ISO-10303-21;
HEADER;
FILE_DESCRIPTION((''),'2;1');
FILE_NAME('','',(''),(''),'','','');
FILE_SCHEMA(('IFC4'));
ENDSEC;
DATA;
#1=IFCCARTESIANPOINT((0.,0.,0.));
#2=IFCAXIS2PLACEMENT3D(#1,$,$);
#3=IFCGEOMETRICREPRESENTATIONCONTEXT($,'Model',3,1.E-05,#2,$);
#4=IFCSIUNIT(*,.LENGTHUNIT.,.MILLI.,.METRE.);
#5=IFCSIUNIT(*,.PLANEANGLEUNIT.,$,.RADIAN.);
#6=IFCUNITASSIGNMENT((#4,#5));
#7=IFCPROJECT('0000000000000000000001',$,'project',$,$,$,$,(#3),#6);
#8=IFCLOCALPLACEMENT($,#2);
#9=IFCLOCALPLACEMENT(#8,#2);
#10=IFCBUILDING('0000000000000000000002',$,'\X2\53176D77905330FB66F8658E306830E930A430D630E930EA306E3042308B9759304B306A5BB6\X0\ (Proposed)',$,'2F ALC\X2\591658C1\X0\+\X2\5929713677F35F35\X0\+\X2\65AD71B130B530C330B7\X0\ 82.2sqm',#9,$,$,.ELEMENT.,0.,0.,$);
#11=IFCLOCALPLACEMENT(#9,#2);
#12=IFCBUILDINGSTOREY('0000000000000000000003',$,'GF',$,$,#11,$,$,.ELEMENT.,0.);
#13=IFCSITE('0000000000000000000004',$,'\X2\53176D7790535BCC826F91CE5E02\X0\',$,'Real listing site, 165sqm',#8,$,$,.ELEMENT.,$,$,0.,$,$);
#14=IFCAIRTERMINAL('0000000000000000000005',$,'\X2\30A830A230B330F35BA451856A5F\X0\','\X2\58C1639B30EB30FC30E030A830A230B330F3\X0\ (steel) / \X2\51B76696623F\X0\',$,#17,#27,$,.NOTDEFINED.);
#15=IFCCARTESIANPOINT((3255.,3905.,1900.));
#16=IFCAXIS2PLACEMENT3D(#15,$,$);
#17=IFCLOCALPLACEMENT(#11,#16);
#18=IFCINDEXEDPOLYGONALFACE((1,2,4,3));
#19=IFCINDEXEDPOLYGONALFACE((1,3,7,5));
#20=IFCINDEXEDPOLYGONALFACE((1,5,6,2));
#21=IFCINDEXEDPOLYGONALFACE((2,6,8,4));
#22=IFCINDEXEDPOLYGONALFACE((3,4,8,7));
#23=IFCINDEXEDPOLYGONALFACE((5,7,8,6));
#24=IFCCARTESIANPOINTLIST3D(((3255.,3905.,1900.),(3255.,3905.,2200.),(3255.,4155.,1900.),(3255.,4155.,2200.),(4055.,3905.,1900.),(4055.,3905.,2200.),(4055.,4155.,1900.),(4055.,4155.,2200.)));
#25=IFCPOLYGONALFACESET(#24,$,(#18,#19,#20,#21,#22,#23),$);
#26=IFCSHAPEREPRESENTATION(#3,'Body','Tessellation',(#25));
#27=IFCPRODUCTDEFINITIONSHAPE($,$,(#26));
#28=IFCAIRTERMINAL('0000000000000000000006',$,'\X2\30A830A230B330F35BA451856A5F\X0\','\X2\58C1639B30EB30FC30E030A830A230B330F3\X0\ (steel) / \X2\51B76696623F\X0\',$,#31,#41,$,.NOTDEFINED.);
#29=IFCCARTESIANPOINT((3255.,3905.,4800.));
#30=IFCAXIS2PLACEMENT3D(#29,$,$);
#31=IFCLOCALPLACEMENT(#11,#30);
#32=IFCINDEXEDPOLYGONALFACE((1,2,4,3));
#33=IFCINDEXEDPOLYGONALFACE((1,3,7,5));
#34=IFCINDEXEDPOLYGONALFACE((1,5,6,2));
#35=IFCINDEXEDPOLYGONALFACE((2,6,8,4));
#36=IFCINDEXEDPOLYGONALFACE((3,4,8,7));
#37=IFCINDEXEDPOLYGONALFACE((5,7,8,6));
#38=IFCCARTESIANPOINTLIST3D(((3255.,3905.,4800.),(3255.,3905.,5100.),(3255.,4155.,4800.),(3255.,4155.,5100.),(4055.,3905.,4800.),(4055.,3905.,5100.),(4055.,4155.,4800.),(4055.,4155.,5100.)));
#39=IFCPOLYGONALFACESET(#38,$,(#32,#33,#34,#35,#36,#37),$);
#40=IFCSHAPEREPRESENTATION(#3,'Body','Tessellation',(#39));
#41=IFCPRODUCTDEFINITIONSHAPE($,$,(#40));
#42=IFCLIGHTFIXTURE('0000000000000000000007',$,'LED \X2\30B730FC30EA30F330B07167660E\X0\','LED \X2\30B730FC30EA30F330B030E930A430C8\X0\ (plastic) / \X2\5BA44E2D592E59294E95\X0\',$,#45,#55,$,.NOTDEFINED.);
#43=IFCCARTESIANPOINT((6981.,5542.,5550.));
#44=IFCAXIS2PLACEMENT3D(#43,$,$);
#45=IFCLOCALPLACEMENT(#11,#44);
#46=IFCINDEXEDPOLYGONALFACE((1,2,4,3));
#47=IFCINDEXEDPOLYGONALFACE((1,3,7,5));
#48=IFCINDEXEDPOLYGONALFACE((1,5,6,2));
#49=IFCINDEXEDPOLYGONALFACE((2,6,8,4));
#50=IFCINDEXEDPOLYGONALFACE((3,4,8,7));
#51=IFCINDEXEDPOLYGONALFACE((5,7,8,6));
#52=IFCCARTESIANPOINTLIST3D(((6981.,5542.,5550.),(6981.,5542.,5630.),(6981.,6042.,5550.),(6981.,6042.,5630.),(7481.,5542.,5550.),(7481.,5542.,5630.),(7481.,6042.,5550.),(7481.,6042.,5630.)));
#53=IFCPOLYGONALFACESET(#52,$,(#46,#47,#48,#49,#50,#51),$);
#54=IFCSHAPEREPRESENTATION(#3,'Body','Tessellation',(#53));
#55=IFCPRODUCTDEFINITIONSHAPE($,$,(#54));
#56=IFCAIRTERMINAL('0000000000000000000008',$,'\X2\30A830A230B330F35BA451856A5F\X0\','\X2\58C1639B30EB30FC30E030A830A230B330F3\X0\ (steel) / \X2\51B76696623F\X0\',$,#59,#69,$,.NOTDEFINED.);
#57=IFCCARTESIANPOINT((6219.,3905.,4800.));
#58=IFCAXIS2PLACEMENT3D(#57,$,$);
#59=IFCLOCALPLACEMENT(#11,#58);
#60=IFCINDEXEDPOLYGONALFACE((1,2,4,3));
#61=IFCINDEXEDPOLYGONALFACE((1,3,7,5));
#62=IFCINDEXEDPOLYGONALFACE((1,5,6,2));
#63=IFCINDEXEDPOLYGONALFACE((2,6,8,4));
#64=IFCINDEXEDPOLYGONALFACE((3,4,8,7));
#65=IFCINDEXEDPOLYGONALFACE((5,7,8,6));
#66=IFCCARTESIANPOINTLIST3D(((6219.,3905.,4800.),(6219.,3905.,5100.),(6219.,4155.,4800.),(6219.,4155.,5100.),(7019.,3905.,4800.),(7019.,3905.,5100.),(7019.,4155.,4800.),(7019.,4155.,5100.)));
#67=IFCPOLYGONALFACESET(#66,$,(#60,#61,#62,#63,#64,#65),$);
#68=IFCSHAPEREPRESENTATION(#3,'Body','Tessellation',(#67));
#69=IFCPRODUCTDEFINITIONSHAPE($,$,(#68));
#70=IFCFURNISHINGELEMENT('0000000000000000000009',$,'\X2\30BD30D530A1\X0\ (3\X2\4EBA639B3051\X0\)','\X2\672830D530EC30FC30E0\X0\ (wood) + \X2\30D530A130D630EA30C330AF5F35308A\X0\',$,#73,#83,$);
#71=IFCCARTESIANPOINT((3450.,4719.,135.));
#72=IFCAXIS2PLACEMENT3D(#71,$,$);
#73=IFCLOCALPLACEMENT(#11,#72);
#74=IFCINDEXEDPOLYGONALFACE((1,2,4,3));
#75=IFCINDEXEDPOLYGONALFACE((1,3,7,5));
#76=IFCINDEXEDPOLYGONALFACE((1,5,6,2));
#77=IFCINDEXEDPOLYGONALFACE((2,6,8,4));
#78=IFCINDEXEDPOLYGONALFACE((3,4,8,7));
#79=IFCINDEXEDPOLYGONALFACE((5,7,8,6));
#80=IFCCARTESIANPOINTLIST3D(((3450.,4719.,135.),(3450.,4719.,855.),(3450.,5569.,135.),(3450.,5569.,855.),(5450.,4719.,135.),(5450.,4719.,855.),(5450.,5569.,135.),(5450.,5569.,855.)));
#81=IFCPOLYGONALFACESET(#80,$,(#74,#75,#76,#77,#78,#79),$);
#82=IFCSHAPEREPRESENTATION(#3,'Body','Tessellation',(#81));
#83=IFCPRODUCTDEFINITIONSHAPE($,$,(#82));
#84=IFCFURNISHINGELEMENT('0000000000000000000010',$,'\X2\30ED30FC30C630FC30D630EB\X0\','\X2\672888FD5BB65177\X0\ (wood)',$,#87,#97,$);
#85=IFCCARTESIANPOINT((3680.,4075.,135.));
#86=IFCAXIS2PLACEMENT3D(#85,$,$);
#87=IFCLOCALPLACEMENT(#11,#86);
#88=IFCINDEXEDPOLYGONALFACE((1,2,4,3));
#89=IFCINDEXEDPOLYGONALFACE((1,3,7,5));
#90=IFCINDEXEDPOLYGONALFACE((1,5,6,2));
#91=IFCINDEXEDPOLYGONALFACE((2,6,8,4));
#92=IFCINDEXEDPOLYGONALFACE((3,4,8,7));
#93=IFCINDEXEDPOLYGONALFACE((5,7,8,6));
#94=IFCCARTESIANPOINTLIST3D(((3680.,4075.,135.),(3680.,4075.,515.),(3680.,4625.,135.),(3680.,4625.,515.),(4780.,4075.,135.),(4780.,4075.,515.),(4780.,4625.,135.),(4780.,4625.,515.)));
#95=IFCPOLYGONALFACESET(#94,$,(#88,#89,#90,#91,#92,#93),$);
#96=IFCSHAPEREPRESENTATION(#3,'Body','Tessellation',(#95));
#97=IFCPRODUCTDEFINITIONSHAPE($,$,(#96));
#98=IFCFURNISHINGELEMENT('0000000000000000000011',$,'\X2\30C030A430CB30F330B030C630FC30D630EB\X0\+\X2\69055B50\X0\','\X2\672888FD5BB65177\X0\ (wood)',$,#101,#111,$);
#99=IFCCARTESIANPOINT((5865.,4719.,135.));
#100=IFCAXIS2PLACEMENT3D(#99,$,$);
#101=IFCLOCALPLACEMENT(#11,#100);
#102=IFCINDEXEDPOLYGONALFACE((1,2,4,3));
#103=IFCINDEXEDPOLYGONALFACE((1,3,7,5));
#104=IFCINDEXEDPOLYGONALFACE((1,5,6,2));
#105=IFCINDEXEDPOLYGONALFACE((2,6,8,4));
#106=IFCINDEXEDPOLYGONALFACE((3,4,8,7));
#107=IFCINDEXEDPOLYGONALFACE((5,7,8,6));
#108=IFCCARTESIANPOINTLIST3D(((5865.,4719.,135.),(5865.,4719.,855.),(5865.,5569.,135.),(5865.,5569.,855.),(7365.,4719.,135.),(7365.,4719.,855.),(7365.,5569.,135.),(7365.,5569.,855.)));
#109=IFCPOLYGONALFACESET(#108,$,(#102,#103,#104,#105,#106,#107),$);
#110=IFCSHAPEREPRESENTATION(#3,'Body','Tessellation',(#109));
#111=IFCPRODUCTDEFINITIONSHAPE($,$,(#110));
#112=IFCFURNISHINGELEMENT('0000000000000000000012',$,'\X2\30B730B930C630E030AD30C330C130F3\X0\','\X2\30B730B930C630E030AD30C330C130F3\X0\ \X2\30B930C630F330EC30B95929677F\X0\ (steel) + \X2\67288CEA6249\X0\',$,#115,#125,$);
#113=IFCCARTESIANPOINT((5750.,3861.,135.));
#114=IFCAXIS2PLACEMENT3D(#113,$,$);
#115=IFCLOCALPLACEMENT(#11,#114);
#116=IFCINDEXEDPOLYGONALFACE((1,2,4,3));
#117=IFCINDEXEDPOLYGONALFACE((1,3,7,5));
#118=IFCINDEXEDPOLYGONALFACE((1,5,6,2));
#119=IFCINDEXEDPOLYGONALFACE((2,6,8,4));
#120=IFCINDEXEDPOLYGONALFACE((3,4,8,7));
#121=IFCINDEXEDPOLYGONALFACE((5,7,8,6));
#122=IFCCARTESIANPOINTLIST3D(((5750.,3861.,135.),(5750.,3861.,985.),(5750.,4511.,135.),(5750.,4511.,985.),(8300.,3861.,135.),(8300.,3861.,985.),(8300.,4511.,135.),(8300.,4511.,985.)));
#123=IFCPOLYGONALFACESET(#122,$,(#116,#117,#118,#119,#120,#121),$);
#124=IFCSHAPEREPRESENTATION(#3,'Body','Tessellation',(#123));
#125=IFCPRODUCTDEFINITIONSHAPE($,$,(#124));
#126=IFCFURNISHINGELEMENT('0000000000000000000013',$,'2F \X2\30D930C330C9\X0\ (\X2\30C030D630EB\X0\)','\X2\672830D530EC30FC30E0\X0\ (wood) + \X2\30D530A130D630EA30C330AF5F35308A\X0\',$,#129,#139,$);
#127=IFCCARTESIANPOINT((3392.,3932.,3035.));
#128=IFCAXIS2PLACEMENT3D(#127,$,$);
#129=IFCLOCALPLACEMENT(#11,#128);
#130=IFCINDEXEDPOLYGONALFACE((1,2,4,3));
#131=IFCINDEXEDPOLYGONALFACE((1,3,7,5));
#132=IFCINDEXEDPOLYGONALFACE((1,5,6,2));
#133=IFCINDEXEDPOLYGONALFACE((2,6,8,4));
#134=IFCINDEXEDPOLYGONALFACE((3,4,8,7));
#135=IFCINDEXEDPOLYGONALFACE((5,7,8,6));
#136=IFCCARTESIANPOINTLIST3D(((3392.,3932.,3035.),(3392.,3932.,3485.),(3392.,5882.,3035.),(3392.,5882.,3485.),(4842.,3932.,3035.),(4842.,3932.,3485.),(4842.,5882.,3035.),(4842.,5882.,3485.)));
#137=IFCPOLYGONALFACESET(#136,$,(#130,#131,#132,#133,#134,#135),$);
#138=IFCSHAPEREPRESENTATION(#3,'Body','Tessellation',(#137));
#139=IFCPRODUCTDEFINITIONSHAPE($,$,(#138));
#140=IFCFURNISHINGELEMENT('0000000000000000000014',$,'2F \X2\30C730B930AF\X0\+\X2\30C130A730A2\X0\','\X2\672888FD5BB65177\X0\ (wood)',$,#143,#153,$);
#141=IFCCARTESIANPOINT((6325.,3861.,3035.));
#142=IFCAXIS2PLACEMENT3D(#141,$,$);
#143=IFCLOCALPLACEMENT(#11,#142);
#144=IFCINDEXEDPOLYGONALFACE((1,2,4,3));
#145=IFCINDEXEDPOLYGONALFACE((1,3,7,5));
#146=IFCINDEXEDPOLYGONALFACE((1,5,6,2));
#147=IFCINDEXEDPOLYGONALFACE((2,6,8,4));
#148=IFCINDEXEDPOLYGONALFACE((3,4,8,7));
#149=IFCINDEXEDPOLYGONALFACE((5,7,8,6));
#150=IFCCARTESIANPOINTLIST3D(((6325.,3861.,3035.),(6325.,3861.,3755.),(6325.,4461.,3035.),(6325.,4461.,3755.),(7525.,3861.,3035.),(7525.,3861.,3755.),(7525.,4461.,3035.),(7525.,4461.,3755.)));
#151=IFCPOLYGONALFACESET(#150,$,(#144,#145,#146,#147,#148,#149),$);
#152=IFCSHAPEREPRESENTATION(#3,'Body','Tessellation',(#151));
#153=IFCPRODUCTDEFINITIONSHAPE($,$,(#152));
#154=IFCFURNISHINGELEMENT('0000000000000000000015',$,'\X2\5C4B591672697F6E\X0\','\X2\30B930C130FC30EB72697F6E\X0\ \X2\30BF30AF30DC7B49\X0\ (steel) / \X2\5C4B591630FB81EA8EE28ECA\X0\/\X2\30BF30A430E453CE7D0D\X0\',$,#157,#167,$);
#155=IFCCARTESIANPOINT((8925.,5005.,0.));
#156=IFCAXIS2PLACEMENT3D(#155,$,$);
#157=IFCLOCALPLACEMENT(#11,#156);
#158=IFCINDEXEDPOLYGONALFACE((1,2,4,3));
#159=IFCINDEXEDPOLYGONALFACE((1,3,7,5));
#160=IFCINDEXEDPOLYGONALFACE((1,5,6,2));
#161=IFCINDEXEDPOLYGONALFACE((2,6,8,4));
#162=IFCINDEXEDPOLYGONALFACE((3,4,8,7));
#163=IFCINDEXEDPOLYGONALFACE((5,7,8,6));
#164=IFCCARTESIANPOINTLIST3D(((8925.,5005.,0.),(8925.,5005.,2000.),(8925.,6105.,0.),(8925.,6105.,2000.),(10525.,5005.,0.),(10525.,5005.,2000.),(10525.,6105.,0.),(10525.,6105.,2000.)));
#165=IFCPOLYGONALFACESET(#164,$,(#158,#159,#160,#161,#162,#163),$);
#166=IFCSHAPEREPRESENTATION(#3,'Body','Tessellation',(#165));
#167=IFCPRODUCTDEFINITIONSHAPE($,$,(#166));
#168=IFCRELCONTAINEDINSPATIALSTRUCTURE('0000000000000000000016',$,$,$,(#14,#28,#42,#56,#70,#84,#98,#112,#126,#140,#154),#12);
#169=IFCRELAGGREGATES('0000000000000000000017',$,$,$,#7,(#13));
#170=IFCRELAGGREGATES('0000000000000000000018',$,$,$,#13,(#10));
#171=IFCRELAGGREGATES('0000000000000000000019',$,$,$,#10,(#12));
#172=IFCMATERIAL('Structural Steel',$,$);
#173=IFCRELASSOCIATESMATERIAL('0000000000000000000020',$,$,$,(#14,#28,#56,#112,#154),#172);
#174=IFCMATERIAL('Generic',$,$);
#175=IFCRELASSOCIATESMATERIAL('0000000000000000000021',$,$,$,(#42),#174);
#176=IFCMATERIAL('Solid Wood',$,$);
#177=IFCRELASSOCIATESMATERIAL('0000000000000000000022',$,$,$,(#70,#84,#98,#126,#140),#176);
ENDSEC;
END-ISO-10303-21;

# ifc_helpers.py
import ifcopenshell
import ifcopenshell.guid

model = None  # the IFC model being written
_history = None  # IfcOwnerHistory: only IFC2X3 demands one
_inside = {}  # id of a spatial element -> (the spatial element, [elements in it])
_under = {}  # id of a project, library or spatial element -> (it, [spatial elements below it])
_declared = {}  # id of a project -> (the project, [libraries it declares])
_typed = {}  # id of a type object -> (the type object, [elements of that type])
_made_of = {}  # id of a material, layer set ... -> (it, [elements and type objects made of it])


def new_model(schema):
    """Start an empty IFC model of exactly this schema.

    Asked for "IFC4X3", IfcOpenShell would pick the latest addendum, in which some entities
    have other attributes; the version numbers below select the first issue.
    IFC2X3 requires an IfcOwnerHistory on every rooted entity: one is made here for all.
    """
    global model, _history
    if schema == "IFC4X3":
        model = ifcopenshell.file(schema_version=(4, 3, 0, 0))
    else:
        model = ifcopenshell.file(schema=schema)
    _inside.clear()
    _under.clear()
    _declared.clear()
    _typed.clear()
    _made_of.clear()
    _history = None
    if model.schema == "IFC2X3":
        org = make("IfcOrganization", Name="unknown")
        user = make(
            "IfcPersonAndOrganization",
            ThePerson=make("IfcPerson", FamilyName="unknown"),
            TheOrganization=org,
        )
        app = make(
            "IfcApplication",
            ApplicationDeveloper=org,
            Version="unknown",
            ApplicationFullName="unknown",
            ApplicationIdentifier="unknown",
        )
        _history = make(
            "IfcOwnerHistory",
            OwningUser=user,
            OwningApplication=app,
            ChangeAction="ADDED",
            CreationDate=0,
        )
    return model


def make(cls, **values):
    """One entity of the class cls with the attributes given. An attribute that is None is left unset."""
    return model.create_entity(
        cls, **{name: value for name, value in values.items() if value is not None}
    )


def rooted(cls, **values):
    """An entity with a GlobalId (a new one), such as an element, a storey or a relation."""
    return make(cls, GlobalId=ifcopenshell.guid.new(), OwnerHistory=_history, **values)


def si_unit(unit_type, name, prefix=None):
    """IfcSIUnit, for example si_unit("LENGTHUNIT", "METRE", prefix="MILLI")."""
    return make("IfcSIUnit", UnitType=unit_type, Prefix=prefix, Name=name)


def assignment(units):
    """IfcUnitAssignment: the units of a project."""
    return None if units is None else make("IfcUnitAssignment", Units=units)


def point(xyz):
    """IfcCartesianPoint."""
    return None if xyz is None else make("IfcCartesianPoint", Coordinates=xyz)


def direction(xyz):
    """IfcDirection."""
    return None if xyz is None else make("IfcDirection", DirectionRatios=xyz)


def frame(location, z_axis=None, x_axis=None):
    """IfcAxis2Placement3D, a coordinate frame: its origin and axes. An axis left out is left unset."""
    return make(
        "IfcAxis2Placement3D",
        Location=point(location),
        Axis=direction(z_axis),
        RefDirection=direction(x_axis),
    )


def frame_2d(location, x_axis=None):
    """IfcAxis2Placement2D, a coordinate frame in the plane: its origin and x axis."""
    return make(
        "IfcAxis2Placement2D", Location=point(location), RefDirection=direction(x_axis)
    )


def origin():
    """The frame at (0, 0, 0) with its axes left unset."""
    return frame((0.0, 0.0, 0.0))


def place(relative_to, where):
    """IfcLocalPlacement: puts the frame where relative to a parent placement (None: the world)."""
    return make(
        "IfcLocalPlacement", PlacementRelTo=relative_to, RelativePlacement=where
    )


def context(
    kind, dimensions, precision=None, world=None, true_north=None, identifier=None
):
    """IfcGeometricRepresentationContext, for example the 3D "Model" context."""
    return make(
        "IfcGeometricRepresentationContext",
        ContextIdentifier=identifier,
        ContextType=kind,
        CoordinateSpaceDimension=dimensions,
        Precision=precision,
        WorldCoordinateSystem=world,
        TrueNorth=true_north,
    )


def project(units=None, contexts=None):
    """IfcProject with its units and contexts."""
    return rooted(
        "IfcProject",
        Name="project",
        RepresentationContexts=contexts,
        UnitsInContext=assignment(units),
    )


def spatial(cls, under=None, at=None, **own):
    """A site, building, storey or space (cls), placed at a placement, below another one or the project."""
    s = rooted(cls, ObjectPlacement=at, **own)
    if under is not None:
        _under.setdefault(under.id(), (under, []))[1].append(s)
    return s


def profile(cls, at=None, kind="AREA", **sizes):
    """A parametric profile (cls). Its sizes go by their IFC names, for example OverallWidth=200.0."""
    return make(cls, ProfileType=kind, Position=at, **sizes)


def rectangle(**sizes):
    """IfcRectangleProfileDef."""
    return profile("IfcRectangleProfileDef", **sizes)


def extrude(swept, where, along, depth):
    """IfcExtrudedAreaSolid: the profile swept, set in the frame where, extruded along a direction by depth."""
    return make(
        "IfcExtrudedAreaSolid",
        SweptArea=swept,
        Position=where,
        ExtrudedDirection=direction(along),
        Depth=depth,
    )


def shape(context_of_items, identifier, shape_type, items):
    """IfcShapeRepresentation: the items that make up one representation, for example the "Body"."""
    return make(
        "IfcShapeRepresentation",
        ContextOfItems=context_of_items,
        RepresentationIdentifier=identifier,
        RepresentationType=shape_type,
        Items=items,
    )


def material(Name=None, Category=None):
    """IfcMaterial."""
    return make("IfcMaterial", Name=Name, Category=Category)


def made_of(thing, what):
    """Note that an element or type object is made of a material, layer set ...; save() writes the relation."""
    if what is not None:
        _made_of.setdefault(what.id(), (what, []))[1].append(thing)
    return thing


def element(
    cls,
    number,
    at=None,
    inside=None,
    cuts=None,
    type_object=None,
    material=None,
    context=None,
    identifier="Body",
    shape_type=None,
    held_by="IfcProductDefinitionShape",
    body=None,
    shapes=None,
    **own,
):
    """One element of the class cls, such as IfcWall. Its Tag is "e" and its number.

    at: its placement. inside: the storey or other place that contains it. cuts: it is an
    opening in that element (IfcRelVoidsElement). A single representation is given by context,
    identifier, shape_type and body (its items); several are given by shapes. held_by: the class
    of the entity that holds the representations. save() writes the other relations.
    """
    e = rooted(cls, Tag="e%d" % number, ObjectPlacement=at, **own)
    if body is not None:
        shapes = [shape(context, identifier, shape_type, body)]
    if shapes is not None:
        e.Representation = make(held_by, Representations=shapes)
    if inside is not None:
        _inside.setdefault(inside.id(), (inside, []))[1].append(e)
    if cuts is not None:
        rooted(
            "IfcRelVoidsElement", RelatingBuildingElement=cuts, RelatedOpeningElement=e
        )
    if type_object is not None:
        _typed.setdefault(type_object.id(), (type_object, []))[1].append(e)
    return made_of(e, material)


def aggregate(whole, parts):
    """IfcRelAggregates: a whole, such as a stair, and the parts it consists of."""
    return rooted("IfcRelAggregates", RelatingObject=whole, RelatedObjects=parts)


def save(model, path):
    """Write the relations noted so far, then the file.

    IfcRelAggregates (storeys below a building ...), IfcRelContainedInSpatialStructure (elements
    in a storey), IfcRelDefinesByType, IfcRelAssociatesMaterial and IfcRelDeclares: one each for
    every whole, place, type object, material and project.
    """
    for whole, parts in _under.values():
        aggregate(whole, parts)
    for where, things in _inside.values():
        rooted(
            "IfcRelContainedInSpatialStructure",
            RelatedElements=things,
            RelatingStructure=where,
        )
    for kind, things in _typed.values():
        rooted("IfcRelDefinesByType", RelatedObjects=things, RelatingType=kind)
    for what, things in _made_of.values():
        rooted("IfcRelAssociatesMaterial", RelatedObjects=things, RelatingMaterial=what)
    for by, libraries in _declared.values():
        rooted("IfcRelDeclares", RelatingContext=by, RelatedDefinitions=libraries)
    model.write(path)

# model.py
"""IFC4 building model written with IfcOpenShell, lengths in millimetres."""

from ifc_helpers import new_model, si_unit, frame, frame_2d, origin, place, context, project, spatial, rectangle, extrude, material, element, save


model = new_model("IFC4")

# Units and contexts
model_context = context("Model", 3, precision=1e-05, world=origin())
ifc_project = project(units=[si_unit("LENGTHUNIT", "METRE", prefix="MILLI"), si_unit("PLANEANGLEUNIT", "RADIAN")], contexts=[model_context])

# Site, building, storey
site_placement = place(None, origin())
site = spatial("IfcSite", under=ifc_project, at=site_placement, Name="北海道富良野市", ObjectType="Real listing site, 165sqm", CompositionType="ELEMENT", RefElevation=0.0)
building_placement = place(site_placement, origin())
building = spatial("IfcBuilding", under=site, at=building_placement, Name="北海道・書斎とライブラリのある静かな家 (Proposed)", ObjectType="2F ALC外壁+天然石張+断熱サッシ 82.2sqm", CompositionType="ELEMENT", ElevationOfRefHeight=0.0, ElevationOfTerrain=0.0)
storey_placement = place(building_placement, origin())
storey = spatial("IfcBuildingStorey", under=building, at=storey_placement, Name="GF", CompositionType="ELEMENT", Elevation=0.0)

# Shared definitions
ifc_material_1 = material(Name="Solid Wood")

# Shared definitions
ifc_material_2 = material(Name="Generic")

# Shared definitions
ifc_material_3 = material(Name="Structural Steel")

# Air terminals
air_terminal_1_placement = place(storey_placement, frame((3255.0, 3905.0, 1900.0)))
element("IfcAirTerminal", 1, at=air_terminal_1_placement, inside=storey, material=ifc_material_3, Name="エアコン室内機", Description="壁掛ルームエアコン (steel) / 冷暖房", PredefinedType="NOTDEFINED", context=model_context, shape_type="SweptSolid", body=[
    extrude(rectangle(XDim=800.0, YDim=250.0, at=frame_2d((400.0, 125.0))), frame((3255.0, 3905.0, 1900.0)), (0.0, 0.0, 1.0), 300.0),
])
air_terminal_2_placement = place(storey_placement, frame((3255.0, 3905.0, 4800.0)))
element("IfcAirTerminal", 2, at=air_terminal_2_placement, inside=storey, material=ifc_material_3, Name="エアコン室内機", Description="壁掛ルームエアコン (steel) / 冷暖房", PredefinedType="NOTDEFINED", context=model_context, shape_type="SweptSolid", body=[
    extrude(rectangle(XDim=800.0, YDim=250.0, at=frame_2d((400.0, 125.0))), frame((3255.0, 3905.0, 4800.0)), (0.0, 0.0, 1.0), 300.0),
])

# Light fixture
light_fixture_placement = place(storey_placement, frame((6981.0, 5542.0, 5550.0)))
element("IfcLightFixture", 3, at=light_fixture_placement, inside=storey, material=ifc_material_2, Name="LED シーリング照明", Description="LED シーリングライト (plastic) / 室中央天井", PredefinedType="NOTDEFINED", context=model_context, shape_type="SweptSolid", body=[
    extrude(rectangle(XDim=500.0, YDim=500.0, at=frame_2d((250.0, 250.0))), frame((6981.0, 5542.0, 5550.0)), (0.0, 0.0, 1.0), 80.0),
])

# Air terminal
air_terminal_3_placement = place(storey_placement, frame((6219.0, 3905.0, 4800.0)))
element("IfcAirTerminal", 4, at=air_terminal_3_placement, inside=storey, material=ifc_material_3, Name="エアコン室内機", Description="壁掛ルームエアコン (steel) / 冷暖房", PredefinedType="NOTDEFINED", context=model_context, shape_type="SweptSolid", body=[
    extrude(rectangle(XDim=800.0, YDim=250.0, at=frame_2d((400.0, 125.0))), frame((6219.0, 3905.0, 4800.0)), (0.0, 0.0, 1.0), 300.0),
])

# Furnishing elements
furnishing_1_placement = place(storey_placement, frame((3450.0, 4719.0, 135.0)))
element("IfcFurnishingElement", 5, at=furnishing_1_placement, inside=storey, material=ifc_material_1, Name="ソファ (3人掛け)", Description="木フレーム (wood) + ファブリック張り", context=model_context, shape_type="SweptSolid", body=[
    extrude(rectangle(XDim=2000.0, YDim=850.0, at=frame_2d((1000.0, 425.0))), frame((3450.0, 4719.0, 135.0)), (0.0, 0.0, 1.0), 720.0),
])
furnishing_2_placement = place(storey_placement, frame((3680.0, 4075.0, 135.0)))
element("IfcFurnishingElement", 6, at=furnishing_2_placement, inside=storey, material=ifc_material_1, Name="ローテーブル", Description="木製家具 (wood)", context=model_context, shape_type="SweptSolid", body=[
    extrude(rectangle(XDim=1100.0, YDim=550.0, at=frame_2d((550.0, 275.0))), frame((3680.0, 4075.0, 135.0)), (0.0, 0.0, 1.0), 380.0),
])
furnishing_3_placement = place(storey_placement, frame((5865.0, 4719.0, 135.0)))
element("IfcFurnishingElement", 7, at=furnishing_3_placement, inside=storey, material=ifc_material_1, Name="ダイニングテーブル+椅子", Description="木製家具 (wood)", context=model_context, shape_type="SweptSolid", body=[
    extrude(rectangle(XDim=1500.0, YDim=850.0, at=frame_2d((750.0, 425.0))), frame((5865.0, 4719.0, 135.0)), (0.0, 0.0, 1.0), 720.0),
])
furnishing_4_placement = place(storey_placement, frame((5750.0, 3861.0, 135.0)))
element("IfcFurnishingElement", 8, at=furnishing_4_placement, inside=storey, material=ifc_material_3, Name="システムキッチン", Description="システムキッチン ステンレス天板 (steel) + 木質扉", context=model_context, shape_type="SweptSolid", body=[
    extrude(rectangle(XDim=2550.0, YDim=650.0, at=frame_2d((1275.0, 325.0))), frame((5750.0, 3861.0, 135.0)), (0.0, 0.0, 1.0), 850.0),
])
furnishing_5_placement = place(storey_placement, frame((3392.0, 3932.0, 3035.0)))
element("IfcFurnishingElement", 9, at=furnishing_5_placement, inside=storey, material=ifc_material_1, Name="2F ベッド (ダブル)", Description="木フレーム (wood) + ファブリック張り", context=model_context, shape_type="SweptSolid", body=[
    extrude(rectangle(XDim=1450.0, YDim=1950.0, at=frame_2d((725.0, 975.0))), frame((3392.0, 3932.0, 3035.0)), (0.0, 0.0, 1.0), 450.0),
])
furnishing_6_placement = place(storey_placement, frame((6325.0, 3861.0, 3035.0)))
element("IfcFurnishingElement", 10, at=furnishing_6_placement, inside=storey, material=ifc_material_1, Name="2F デスク+チェア", Description="木製家具 (wood)", context=model_context, shape_type="SweptSolid", body=[
    extrude(rectangle(XDim=1200.0, YDim=600.0, at=frame_2d((600.0, 300.0))), frame((6325.0, 3861.0, 3035.0)), (0.0, 0.0, 1.0), 720.0),
])
furnishing_7_placement = place(storey_placement, frame((8925.0, 5005.0, 0.0)))
element("IfcFurnishingElement", 11, at=furnishing_7_placement, inside=storey, material=ifc_material_3, Name="屋外物置", Description="スチール物置 タクボ等 (steel) / 屋外・自転車/タイヤ収納", context=model_context, shape_type="SweptSolid", body=[
    extrude(rectangle(XDim=1600.0, YDim=1100.0, at=frame_2d((800.0, 550.0))), frame((8925.0, 5005.0, 0.0)), (0.0, 0.0, 1.0), 2000.0),
])

save(model, "model.ifc")
